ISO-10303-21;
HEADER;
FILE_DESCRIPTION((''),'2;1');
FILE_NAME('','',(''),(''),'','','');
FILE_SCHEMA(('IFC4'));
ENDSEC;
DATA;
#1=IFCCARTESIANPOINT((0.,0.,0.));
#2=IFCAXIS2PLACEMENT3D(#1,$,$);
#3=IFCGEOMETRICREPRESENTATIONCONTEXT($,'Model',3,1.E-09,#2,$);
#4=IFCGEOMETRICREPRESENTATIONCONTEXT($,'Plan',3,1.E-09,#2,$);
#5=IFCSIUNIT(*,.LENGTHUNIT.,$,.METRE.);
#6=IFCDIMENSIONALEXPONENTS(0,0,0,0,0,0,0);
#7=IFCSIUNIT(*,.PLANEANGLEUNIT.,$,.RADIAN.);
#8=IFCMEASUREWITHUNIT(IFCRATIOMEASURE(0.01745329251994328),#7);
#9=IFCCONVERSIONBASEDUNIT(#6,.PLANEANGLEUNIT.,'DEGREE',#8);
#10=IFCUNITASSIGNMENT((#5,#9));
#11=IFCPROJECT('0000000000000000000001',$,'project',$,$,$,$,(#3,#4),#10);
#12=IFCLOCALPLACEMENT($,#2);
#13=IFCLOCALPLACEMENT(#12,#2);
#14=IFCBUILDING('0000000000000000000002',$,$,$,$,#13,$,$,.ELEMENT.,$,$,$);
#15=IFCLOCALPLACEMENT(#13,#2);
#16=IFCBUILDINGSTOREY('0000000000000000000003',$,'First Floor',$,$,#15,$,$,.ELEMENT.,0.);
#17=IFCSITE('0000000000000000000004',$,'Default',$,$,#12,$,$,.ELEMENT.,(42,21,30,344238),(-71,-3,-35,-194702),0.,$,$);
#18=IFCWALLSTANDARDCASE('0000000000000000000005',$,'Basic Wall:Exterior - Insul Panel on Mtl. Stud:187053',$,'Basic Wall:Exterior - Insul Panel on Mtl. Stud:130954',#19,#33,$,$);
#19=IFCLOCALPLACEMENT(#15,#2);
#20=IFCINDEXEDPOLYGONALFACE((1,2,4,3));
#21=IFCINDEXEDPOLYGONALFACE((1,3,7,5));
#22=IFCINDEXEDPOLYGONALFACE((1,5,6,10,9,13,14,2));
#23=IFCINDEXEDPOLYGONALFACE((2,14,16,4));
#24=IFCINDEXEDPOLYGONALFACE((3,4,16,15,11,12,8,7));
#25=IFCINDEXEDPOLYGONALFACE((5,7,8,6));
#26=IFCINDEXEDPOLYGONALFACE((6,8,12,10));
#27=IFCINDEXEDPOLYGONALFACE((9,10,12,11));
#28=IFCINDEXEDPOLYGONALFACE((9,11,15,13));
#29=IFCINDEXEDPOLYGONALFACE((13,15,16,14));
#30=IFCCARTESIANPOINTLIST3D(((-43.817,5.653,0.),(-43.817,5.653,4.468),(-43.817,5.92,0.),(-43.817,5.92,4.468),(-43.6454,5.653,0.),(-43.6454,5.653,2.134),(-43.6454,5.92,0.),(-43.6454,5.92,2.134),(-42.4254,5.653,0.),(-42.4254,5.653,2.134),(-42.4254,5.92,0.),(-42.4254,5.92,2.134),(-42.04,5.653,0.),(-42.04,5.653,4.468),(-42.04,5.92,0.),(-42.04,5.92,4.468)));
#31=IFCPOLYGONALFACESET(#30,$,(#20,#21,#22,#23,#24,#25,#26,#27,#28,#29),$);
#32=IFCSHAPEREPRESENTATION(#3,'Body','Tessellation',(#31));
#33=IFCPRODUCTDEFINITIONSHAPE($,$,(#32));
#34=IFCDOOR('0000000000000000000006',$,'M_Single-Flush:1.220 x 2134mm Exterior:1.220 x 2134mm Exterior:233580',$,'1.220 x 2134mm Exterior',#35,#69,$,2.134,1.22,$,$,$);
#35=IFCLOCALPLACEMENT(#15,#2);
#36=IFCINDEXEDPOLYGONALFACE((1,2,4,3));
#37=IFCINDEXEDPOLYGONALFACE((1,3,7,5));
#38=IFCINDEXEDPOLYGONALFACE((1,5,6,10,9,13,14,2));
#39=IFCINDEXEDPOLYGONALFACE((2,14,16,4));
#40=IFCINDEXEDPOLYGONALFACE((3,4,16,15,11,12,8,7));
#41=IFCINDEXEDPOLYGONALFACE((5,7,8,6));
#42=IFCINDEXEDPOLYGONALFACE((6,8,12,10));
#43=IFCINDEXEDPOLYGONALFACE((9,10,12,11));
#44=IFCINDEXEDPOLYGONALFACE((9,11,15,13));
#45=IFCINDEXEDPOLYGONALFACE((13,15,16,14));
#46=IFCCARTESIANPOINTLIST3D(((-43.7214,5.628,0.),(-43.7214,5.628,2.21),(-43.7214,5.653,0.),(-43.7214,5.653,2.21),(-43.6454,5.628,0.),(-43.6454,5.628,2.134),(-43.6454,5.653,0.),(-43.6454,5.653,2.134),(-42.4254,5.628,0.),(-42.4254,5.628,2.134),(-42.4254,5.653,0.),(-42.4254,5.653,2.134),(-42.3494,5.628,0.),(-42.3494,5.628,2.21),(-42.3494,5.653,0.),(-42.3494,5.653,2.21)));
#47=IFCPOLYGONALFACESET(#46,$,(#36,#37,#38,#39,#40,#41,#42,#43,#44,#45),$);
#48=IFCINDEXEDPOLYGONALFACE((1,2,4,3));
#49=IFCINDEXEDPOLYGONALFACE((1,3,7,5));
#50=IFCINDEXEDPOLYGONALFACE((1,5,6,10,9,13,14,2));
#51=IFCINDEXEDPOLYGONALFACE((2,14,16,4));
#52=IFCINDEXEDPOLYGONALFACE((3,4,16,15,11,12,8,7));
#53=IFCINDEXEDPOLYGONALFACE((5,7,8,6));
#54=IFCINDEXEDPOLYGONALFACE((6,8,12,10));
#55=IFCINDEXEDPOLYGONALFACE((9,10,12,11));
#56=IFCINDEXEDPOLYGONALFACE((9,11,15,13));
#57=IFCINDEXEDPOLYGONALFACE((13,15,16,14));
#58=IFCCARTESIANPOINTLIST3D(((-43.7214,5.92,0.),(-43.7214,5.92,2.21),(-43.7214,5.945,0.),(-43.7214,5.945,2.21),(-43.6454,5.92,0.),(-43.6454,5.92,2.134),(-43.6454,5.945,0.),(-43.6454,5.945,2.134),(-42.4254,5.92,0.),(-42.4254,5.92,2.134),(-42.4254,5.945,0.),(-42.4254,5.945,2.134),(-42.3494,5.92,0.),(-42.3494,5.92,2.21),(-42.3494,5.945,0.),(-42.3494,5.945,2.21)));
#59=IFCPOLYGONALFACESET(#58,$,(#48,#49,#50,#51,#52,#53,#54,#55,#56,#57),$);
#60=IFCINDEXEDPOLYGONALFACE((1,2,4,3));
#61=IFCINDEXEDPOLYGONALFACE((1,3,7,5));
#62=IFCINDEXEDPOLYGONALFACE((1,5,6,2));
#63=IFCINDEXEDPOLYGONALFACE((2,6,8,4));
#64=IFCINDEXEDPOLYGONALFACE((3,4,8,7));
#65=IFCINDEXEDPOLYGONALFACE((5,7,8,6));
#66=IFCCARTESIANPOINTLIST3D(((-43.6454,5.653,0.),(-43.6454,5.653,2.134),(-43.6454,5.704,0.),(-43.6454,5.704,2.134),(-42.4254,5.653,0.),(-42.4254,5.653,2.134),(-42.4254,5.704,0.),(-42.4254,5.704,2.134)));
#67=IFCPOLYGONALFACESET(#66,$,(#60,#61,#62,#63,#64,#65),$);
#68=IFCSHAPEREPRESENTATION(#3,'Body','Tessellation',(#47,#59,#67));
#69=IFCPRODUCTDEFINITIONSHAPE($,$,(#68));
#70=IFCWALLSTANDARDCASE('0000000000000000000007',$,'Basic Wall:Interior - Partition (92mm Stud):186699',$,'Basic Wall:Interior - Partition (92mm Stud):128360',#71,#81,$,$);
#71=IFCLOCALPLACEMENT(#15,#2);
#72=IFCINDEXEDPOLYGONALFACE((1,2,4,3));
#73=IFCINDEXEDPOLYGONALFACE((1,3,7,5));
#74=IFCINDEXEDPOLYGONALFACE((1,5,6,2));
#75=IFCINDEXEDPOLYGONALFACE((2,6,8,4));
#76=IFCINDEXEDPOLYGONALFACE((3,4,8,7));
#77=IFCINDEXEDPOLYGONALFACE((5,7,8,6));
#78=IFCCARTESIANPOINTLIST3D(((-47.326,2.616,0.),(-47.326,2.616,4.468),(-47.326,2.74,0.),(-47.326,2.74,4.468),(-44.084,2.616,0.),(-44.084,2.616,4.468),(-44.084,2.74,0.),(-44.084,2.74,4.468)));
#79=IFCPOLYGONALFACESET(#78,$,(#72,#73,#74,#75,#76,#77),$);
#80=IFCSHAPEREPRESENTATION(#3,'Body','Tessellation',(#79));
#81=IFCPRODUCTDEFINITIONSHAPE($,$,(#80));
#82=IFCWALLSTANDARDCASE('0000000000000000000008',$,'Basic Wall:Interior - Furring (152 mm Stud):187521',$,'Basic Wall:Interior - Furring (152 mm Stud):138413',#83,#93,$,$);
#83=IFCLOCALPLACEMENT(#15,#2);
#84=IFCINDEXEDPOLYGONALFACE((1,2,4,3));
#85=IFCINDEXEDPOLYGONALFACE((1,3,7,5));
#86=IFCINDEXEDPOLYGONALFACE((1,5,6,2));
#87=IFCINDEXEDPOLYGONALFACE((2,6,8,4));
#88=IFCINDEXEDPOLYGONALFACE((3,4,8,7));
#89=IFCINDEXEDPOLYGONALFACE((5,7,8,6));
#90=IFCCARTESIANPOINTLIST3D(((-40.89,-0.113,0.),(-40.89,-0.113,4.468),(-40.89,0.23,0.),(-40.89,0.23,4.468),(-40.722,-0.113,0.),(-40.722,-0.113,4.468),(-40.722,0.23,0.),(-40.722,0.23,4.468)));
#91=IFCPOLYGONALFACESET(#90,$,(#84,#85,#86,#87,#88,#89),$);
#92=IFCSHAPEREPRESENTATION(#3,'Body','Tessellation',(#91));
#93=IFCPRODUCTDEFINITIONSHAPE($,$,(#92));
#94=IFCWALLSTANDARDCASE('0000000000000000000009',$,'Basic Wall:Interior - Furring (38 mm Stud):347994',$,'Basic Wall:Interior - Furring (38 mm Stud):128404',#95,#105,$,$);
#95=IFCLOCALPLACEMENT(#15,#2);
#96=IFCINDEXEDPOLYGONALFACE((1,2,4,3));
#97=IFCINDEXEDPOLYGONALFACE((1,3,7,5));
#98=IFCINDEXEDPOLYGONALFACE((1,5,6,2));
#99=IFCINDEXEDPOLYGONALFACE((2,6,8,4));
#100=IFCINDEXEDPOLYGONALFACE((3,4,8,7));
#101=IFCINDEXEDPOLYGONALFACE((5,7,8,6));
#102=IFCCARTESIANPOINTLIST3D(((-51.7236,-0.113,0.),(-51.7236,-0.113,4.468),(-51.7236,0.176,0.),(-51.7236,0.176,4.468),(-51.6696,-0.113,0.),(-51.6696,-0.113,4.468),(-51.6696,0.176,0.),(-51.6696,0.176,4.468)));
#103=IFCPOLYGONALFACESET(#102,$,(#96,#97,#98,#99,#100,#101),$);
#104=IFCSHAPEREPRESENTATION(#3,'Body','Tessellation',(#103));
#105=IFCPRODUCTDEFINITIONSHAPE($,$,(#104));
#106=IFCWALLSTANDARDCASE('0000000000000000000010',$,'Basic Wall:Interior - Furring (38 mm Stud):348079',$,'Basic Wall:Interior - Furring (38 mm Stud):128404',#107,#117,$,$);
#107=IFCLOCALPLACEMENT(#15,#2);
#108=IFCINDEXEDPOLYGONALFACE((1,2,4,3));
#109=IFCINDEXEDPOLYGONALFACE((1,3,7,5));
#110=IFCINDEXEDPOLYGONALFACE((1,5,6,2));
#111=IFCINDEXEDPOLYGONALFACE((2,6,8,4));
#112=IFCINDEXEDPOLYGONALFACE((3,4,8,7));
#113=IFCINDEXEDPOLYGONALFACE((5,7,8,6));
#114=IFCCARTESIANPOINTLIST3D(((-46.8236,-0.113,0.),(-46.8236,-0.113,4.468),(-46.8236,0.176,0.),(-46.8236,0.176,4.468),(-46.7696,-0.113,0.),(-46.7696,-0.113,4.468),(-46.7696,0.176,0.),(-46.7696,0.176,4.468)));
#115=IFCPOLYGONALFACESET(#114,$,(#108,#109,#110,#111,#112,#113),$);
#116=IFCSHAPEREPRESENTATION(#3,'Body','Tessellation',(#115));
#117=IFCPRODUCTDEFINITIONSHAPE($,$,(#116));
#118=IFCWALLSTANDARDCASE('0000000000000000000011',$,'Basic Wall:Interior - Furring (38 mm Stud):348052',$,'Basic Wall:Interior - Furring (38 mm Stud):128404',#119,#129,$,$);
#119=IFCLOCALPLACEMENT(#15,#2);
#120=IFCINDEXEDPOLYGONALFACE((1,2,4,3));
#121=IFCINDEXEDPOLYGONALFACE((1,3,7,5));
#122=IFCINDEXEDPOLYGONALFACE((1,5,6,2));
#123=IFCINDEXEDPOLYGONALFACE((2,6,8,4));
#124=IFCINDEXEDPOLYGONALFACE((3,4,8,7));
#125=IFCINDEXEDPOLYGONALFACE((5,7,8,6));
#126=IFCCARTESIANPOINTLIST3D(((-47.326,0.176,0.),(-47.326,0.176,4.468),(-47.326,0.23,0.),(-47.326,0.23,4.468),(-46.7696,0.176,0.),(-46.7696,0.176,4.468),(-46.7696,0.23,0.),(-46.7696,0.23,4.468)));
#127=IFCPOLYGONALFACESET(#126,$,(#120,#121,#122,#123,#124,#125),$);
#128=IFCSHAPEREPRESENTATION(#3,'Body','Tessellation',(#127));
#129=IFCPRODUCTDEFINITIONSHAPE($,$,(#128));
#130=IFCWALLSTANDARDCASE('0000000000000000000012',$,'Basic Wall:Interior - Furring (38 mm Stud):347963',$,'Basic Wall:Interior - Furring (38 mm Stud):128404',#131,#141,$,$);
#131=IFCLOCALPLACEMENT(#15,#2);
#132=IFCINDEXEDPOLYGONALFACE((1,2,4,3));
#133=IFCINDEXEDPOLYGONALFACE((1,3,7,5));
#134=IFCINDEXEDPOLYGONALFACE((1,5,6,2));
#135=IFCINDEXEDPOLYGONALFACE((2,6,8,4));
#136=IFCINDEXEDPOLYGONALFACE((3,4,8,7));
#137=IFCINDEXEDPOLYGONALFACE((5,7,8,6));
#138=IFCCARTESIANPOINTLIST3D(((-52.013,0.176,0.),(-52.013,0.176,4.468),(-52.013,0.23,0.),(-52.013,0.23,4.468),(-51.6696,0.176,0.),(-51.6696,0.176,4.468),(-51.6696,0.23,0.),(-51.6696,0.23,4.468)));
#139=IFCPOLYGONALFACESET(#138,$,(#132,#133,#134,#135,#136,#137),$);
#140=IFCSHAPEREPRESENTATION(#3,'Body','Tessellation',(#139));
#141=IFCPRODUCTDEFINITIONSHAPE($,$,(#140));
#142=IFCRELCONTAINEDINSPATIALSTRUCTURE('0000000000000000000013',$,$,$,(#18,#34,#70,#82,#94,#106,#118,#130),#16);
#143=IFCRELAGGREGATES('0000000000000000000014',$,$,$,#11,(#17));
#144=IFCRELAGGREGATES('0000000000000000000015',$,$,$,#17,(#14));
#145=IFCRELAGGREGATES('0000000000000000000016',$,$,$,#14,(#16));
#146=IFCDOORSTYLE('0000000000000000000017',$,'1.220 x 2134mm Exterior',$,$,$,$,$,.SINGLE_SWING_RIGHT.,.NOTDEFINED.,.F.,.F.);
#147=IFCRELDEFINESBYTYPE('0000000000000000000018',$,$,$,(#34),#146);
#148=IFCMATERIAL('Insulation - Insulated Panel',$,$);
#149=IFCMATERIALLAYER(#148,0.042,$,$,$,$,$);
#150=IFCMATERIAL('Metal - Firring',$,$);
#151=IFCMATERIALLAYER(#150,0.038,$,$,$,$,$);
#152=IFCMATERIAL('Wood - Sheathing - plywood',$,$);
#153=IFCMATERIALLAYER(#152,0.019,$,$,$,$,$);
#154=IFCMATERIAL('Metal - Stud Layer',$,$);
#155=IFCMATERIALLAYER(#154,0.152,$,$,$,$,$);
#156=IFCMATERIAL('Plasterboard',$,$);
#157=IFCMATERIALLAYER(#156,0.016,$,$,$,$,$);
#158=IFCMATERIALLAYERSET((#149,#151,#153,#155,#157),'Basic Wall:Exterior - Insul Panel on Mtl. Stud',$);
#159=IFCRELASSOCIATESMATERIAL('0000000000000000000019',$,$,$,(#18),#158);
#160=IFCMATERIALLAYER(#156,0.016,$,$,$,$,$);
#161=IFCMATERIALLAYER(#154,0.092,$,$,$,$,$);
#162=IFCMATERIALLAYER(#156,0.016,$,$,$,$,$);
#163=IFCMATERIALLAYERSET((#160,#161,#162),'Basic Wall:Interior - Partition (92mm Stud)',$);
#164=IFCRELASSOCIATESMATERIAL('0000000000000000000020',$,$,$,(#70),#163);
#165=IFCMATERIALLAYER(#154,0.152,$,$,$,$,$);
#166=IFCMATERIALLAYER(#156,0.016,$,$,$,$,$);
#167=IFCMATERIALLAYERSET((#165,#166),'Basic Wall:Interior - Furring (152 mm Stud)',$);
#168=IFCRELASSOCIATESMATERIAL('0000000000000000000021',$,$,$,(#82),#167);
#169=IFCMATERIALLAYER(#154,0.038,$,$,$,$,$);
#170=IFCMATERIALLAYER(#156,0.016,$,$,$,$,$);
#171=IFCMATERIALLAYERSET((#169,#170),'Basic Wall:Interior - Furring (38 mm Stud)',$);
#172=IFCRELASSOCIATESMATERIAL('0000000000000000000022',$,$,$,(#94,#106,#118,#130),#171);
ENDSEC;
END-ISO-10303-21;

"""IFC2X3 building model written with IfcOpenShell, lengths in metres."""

from ifc_helpers import new_model, entity, si_unit, converted_unit, frame, frame_2d, origin, origin_2d_with_axis, place, context, project, spatial, polyline, rectangle, outline, extrude, source, transform, mapped, material, layer, layer_set, layer_usage, type_object, type_shapes, element, fill, save


model = new_model("IFC2X3")

# Units and contexts
model_context = context("Model", 3, precision=1e-09, world=origin())
plan_context = context("Plan", 3, precision=1e-09, world=origin())
ifc_project = project(units=[si_unit("LENGTHUNIT", "METRE"), converted_unit("PLANEANGLEUNIT", "DEGREE", entity("IfcRatioMeasure", 0.01745329251994328), si_unit("PLANEANGLEUNIT", "RADIAN"), dimensions=[0, 0, 0, 0, 0, 0, 0])], contexts=[model_context, plan_context])

# Site, building, storey
site_placement = place(None, origin())
site = spatial("IfcSite", under=ifc_project, at=site_placement, Name="Default", CompositionType="ELEMENT", RefLatitude=(42, 21, 30, 344238), RefLongitude=(-71, -3, -35, -194702), RefElevation=0.0)
building_placement = place(site_placement, origin())
building = spatial("IfcBuilding", under=site, at=building_placement, CompositionType="ELEMENT")
storey_placement = place(building_placement, origin())
storey = spatial("IfcBuildingStorey", under=building, at=storey_placement, Name="First Floor", CompositionType="ELEMENT", Elevation=0.0)

# Shared definitions
ifc_material_1 = material(Name="Plasterboard")
ifc_layer_1 = layer(ifc_material_1, 0.016)
ifc_material_2 = material(Name="Metal - Stud Layer")
ifc_layer_2 = layer(ifc_material_2, 0.092)
ifc_layer_3 = layer(ifc_material_1, 0.016)
ifc_layer_set_1 = layer_set([ifc_layer_1, ifc_layer_2, ifc_layer_3], Name="Basic Wall:Interior - Partition (92mm Stud)")
ifc_layer_usage_1 = layer_usage(ifc_layer_set_1, "AXIS2", "NEGATIVE", 0.062)

# Shared definitions
ifc_material_3 = material(Name="Insulation - Insulated Panel")
ifc_layer_4 = layer(ifc_material_3, 0.042)
ifc_material_4 = material(Name="Metal - Firring")
ifc_layer_5 = layer(ifc_material_4, 0.038)
ifc_material_5 = material(Name="Wood - Sheathing - plywood")
ifc_layer_6 = layer(ifc_material_5, 0.019)
ifc_layer_7 = layer(ifc_material_2, 0.152)
ifc_layer_8 = layer(ifc_material_1, 0.016)
ifc_layer_set_2 = layer_set([ifc_layer_4, ifc_layer_5, ifc_layer_6, ifc_layer_7, ifc_layer_8], Name="Basic Wall:Exterior - Insul Panel on Mtl. Stud")
ifc_layer_usage_2 = layer_usage(ifc_layer_set_2, "AXIS2", "NEGATIVE", 0.1335)

# Wall, opening, door
wall_1_placement = place(storey_placement, frame((-42.04, 5.7865, 0.0), z_axis=(0.0, 0.0, 1.0), x_axis=(-1.0, 0.0, 0.0)))
wall_1 = element("IfcWallStandardCase", 1, at=wall_1_placement, inside=storey, material=ifc_layer_usage_2, Name="Basic Wall:Exterior - Insul Panel on Mtl. Stud:187053", ObjectType="Basic Wall:Exterior - Insul Panel on Mtl. Stud:130954", context=model_context, shape_type="SweptSolid", body=[
    extrude(rectangle(XDim=1.777, YDim=0.267, at=frame_2d((0.8885, 0.0), x_axis=(-1.0, 0.0))), origin(), (0.0, 0.0, 1.0), 4.468),
])
opening_1_placement = place(wall_1_placement, frame((0.3854, -0.1335, 0.0)))
opening_1 = element("IfcOpeningElement", 2, at=opening_1_placement, cuts=wall_1, ObjectType="Opening", context=model_context, shape_type="SweptSolid", body=[
    extrude(rectangle(XDim=1.22, YDim=2.134, at=frame_2d((1.067, 0.61), x_axis=(0.0, 1.0))), frame((0.0, 0.0, 0.0), z_axis=(0.0, 1.0, 0.0), x_axis=(0.0, 0.0, 1.0)), (0.0, 0.0, 1.0), 0.267),
])
door_style_1 = type_object("IfcDoorStyle", Name="1.220 x 2134mm Exterior", ConstructionType="NOTDEFINED", OperationType="SINGLE_SWING_RIGHT", ParameterTakesPrecedence=False, Sizeable=False)
shared_shape_1 = source(origin(), model_context, "Body", "SweptSolid", [
    extrude(outline(polyline([(-0.686, -1.124), (0.686, -1.124), (0.686, 1.086), (0.61, 1.086), (0.61, -1.048), (-0.61, -1.048), (-0.61, 1.086), (-0.686, 1.086), (-0.686, -1.124)])), frame((0.61, 0.267, 1.086), z_axis=(0.0, 1.0, 0.0), x_axis=(1.0, 0.0, 0.0)), (0.0, 0.0, 1.0), 0.025),
    extrude(outline(polyline([(-1.124, -0.686), (1.086, -0.686), (1.086, -0.61), (-1.048, -0.61), (-1.048, 0.61), (1.086, 0.61), (1.086, 0.686), (-1.124, 0.686), (-1.124, -0.686)])), frame((0.61, -0.025, 1.086), z_axis=(0.0, 1.0, 0.0), x_axis=(0.0, 0.0, -1.0)), (0.0, 0.0, 1.0), 0.025),
    extrude(rectangle(XDim=0.051, YDim=1.22, at=origin_2d_with_axis()), frame((0.61, 0.2415, 0.0), z_axis=(0.0, 0.0, 1.0), x_axis=(0.0, 1.0, 0.0)), (0.0, 0.0, 1.0), 2.134),
])
type_shapes(door_style_1, [shared_shape_1])
door_1_placement = place(opening_1_placement, origin())
door_1 = element("IfcDoor", 3, at=door_1_placement, inside=storey, type_object=door_style_1, Name="M_Single-Flush:1.220 x 2134mm Exterior:1.220 x 2134mm Exterior:233580", ObjectType="1.220 x 2134mm Exterior", OverallHeight=2.134, OverallWidth=1.22, context=model_context, shape_type="MappedRepresentation", body=[
    mapped(shared_shape_1, transform((0.0, 0.0, 0.0), scale=1.0)),
])
fill(opening_1, door_1)

# Walls
wall_2_placement = place(storey_placement, frame((-47.326, 2.678, 0.0)))
element("IfcWallStandardCase", 4, at=wall_2_placement, inside=storey, material=ifc_layer_usage_1, Name="Basic Wall:Interior - Partition (92mm Stud):186699", ObjectType="Basic Wall:Interior - Partition (92mm Stud):128360", context=model_context, shape_type="SweptSolid", body=[
    extrude(rectangle(XDim=3.242, YDim=0.124, at=frame_2d((1.621, 0.0), x_axis=(-1.0, 0.0))), origin(), (0.0, 0.0, 1.0), 4.468),
])
ifc_layer_9 = layer(ifc_material_2, 0.152)
ifc_layer_10 = layer(ifc_material_1, 0.016)
ifc_layer_set_3 = layer_set([ifc_layer_9, ifc_layer_10], Name="Basic Wall:Interior - Furring (152 mm Stud)")
ifc_layer_usage_3 = layer_usage(ifc_layer_set_3, "AXIS2", "POSITIVE", -0.084)
wall_3_placement = place(storey_placement, frame((-40.806, -0.113, 0.0), z_axis=(0.0, 0.0, 1.0), x_axis=(0.0, 1.0, 0.0)))
element("IfcWallStandardCase", 5, at=wall_3_placement, inside=storey, material=ifc_layer_usage_3, Name="Basic Wall:Interior - Furring (152 mm Stud):187521", ObjectType="Basic Wall:Interior - Furring (152 mm Stud):138413", context=model_context, shape_type="SweptSolid", body=[
    extrude(rectangle(XDim=0.343, YDim=0.168, at=frame_2d((0.1715, 0.0), x_axis=(-1.0, 0.0))), origin(), (0.0, 0.0, 1.0), 4.468),
])
ifc_layer_11 = layer(ifc_material_2, 0.038)
ifc_layer_12 = layer(ifc_material_1, 0.016)
ifc_layer_set_4 = layer_set([ifc_layer_11, ifc_layer_12], Name="Basic Wall:Interior - Furring (38 mm Stud)")
ifc_layer_usage_4 = layer_usage(ifc_layer_set_4, "AXIS2", "POSITIVE", -0.027)
wall_4_placement = place(storey_placement, frame((-51.6966, 0.176, 0.0), z_axis=(0.0, 0.0, 1.0), x_axis=(0.0, -1.0, 0.0)))
element("IfcWallStandardCase", 6, at=wall_4_placement, inside=storey, material=ifc_layer_usage_4, Name="Basic Wall:Interior - Furring (38 mm Stud):347994", ObjectType="Basic Wall:Interior - Furring (38 mm Stud):128404", context=model_context, shape_type="SweptSolid", body=[
    extrude(rectangle(XDim=0.289, YDim=0.054, at=frame_2d((0.1445, 0.0), x_axis=(-1.0, 0.0))), origin(), (0.0, 0.0, 1.0), 4.468),
])
wall_5_placement = place(storey_placement, frame((-46.7966, 0.176, 0.0), z_axis=(0.0, 0.0, 1.0), x_axis=(0.0, -1.0, 0.0)))
element("IfcWallStandardCase", 7, at=wall_5_placement, inside=storey, material=ifc_layer_usage_4, Name="Basic Wall:Interior - Furring (38 mm Stud):348079", ObjectType="Basic Wall:Interior - Furring (38 mm Stud):128404", context=model_context, shape_type="SweptSolid", body=[
    extrude(rectangle(XDim=0.289, YDim=0.054, at=frame_2d((0.1445, 0.0), x_axis=(-1.0, 0.0))), origin(), (0.0, 0.0, 1.0), 4.468),
])
wall_6_placement = place(storey_placement, frame((-47.326, 0.203, 0.0)))
element("IfcWallStandardCase", 8, at=wall_6_placement, inside=storey, material=ifc_layer_usage_4, Name="Basic Wall:Interior - Furring (38 mm Stud):348052", ObjectType="Basic Wall:Interior - Furring (38 mm Stud):128404", context=model_context, shape_type="SweptSolid", body=[
    extrude(rectangle(XDim=0.5564, YDim=0.054, at=frame_2d((0.2782, 0.0), x_axis=(-1.0, 0.0))), origin(), (0.0, 0.0, 1.0), 4.468),
])
wall_7_placement = place(storey_placement, frame((-52.013, 0.203, 0.0)))
element("IfcWallStandardCase", 9, at=wall_7_placement, inside=storey, material=ifc_layer_usage_4, Name="Basic Wall:Interior - Furring (38 mm Stud):347963", ObjectType="Basic Wall:Interior - Furring (38 mm Stud):128404", context=model_context, shape_type="SweptSolid", body=[
    extrude(rectangle(XDim=0.3434, YDim=0.054, at=frame_2d((0.1717, 0.0), x_axis=(-1.0, 0.0))), origin(), (0.0, 0.0, 1.0), 4.468),
])

save(model, "model.ifc")
